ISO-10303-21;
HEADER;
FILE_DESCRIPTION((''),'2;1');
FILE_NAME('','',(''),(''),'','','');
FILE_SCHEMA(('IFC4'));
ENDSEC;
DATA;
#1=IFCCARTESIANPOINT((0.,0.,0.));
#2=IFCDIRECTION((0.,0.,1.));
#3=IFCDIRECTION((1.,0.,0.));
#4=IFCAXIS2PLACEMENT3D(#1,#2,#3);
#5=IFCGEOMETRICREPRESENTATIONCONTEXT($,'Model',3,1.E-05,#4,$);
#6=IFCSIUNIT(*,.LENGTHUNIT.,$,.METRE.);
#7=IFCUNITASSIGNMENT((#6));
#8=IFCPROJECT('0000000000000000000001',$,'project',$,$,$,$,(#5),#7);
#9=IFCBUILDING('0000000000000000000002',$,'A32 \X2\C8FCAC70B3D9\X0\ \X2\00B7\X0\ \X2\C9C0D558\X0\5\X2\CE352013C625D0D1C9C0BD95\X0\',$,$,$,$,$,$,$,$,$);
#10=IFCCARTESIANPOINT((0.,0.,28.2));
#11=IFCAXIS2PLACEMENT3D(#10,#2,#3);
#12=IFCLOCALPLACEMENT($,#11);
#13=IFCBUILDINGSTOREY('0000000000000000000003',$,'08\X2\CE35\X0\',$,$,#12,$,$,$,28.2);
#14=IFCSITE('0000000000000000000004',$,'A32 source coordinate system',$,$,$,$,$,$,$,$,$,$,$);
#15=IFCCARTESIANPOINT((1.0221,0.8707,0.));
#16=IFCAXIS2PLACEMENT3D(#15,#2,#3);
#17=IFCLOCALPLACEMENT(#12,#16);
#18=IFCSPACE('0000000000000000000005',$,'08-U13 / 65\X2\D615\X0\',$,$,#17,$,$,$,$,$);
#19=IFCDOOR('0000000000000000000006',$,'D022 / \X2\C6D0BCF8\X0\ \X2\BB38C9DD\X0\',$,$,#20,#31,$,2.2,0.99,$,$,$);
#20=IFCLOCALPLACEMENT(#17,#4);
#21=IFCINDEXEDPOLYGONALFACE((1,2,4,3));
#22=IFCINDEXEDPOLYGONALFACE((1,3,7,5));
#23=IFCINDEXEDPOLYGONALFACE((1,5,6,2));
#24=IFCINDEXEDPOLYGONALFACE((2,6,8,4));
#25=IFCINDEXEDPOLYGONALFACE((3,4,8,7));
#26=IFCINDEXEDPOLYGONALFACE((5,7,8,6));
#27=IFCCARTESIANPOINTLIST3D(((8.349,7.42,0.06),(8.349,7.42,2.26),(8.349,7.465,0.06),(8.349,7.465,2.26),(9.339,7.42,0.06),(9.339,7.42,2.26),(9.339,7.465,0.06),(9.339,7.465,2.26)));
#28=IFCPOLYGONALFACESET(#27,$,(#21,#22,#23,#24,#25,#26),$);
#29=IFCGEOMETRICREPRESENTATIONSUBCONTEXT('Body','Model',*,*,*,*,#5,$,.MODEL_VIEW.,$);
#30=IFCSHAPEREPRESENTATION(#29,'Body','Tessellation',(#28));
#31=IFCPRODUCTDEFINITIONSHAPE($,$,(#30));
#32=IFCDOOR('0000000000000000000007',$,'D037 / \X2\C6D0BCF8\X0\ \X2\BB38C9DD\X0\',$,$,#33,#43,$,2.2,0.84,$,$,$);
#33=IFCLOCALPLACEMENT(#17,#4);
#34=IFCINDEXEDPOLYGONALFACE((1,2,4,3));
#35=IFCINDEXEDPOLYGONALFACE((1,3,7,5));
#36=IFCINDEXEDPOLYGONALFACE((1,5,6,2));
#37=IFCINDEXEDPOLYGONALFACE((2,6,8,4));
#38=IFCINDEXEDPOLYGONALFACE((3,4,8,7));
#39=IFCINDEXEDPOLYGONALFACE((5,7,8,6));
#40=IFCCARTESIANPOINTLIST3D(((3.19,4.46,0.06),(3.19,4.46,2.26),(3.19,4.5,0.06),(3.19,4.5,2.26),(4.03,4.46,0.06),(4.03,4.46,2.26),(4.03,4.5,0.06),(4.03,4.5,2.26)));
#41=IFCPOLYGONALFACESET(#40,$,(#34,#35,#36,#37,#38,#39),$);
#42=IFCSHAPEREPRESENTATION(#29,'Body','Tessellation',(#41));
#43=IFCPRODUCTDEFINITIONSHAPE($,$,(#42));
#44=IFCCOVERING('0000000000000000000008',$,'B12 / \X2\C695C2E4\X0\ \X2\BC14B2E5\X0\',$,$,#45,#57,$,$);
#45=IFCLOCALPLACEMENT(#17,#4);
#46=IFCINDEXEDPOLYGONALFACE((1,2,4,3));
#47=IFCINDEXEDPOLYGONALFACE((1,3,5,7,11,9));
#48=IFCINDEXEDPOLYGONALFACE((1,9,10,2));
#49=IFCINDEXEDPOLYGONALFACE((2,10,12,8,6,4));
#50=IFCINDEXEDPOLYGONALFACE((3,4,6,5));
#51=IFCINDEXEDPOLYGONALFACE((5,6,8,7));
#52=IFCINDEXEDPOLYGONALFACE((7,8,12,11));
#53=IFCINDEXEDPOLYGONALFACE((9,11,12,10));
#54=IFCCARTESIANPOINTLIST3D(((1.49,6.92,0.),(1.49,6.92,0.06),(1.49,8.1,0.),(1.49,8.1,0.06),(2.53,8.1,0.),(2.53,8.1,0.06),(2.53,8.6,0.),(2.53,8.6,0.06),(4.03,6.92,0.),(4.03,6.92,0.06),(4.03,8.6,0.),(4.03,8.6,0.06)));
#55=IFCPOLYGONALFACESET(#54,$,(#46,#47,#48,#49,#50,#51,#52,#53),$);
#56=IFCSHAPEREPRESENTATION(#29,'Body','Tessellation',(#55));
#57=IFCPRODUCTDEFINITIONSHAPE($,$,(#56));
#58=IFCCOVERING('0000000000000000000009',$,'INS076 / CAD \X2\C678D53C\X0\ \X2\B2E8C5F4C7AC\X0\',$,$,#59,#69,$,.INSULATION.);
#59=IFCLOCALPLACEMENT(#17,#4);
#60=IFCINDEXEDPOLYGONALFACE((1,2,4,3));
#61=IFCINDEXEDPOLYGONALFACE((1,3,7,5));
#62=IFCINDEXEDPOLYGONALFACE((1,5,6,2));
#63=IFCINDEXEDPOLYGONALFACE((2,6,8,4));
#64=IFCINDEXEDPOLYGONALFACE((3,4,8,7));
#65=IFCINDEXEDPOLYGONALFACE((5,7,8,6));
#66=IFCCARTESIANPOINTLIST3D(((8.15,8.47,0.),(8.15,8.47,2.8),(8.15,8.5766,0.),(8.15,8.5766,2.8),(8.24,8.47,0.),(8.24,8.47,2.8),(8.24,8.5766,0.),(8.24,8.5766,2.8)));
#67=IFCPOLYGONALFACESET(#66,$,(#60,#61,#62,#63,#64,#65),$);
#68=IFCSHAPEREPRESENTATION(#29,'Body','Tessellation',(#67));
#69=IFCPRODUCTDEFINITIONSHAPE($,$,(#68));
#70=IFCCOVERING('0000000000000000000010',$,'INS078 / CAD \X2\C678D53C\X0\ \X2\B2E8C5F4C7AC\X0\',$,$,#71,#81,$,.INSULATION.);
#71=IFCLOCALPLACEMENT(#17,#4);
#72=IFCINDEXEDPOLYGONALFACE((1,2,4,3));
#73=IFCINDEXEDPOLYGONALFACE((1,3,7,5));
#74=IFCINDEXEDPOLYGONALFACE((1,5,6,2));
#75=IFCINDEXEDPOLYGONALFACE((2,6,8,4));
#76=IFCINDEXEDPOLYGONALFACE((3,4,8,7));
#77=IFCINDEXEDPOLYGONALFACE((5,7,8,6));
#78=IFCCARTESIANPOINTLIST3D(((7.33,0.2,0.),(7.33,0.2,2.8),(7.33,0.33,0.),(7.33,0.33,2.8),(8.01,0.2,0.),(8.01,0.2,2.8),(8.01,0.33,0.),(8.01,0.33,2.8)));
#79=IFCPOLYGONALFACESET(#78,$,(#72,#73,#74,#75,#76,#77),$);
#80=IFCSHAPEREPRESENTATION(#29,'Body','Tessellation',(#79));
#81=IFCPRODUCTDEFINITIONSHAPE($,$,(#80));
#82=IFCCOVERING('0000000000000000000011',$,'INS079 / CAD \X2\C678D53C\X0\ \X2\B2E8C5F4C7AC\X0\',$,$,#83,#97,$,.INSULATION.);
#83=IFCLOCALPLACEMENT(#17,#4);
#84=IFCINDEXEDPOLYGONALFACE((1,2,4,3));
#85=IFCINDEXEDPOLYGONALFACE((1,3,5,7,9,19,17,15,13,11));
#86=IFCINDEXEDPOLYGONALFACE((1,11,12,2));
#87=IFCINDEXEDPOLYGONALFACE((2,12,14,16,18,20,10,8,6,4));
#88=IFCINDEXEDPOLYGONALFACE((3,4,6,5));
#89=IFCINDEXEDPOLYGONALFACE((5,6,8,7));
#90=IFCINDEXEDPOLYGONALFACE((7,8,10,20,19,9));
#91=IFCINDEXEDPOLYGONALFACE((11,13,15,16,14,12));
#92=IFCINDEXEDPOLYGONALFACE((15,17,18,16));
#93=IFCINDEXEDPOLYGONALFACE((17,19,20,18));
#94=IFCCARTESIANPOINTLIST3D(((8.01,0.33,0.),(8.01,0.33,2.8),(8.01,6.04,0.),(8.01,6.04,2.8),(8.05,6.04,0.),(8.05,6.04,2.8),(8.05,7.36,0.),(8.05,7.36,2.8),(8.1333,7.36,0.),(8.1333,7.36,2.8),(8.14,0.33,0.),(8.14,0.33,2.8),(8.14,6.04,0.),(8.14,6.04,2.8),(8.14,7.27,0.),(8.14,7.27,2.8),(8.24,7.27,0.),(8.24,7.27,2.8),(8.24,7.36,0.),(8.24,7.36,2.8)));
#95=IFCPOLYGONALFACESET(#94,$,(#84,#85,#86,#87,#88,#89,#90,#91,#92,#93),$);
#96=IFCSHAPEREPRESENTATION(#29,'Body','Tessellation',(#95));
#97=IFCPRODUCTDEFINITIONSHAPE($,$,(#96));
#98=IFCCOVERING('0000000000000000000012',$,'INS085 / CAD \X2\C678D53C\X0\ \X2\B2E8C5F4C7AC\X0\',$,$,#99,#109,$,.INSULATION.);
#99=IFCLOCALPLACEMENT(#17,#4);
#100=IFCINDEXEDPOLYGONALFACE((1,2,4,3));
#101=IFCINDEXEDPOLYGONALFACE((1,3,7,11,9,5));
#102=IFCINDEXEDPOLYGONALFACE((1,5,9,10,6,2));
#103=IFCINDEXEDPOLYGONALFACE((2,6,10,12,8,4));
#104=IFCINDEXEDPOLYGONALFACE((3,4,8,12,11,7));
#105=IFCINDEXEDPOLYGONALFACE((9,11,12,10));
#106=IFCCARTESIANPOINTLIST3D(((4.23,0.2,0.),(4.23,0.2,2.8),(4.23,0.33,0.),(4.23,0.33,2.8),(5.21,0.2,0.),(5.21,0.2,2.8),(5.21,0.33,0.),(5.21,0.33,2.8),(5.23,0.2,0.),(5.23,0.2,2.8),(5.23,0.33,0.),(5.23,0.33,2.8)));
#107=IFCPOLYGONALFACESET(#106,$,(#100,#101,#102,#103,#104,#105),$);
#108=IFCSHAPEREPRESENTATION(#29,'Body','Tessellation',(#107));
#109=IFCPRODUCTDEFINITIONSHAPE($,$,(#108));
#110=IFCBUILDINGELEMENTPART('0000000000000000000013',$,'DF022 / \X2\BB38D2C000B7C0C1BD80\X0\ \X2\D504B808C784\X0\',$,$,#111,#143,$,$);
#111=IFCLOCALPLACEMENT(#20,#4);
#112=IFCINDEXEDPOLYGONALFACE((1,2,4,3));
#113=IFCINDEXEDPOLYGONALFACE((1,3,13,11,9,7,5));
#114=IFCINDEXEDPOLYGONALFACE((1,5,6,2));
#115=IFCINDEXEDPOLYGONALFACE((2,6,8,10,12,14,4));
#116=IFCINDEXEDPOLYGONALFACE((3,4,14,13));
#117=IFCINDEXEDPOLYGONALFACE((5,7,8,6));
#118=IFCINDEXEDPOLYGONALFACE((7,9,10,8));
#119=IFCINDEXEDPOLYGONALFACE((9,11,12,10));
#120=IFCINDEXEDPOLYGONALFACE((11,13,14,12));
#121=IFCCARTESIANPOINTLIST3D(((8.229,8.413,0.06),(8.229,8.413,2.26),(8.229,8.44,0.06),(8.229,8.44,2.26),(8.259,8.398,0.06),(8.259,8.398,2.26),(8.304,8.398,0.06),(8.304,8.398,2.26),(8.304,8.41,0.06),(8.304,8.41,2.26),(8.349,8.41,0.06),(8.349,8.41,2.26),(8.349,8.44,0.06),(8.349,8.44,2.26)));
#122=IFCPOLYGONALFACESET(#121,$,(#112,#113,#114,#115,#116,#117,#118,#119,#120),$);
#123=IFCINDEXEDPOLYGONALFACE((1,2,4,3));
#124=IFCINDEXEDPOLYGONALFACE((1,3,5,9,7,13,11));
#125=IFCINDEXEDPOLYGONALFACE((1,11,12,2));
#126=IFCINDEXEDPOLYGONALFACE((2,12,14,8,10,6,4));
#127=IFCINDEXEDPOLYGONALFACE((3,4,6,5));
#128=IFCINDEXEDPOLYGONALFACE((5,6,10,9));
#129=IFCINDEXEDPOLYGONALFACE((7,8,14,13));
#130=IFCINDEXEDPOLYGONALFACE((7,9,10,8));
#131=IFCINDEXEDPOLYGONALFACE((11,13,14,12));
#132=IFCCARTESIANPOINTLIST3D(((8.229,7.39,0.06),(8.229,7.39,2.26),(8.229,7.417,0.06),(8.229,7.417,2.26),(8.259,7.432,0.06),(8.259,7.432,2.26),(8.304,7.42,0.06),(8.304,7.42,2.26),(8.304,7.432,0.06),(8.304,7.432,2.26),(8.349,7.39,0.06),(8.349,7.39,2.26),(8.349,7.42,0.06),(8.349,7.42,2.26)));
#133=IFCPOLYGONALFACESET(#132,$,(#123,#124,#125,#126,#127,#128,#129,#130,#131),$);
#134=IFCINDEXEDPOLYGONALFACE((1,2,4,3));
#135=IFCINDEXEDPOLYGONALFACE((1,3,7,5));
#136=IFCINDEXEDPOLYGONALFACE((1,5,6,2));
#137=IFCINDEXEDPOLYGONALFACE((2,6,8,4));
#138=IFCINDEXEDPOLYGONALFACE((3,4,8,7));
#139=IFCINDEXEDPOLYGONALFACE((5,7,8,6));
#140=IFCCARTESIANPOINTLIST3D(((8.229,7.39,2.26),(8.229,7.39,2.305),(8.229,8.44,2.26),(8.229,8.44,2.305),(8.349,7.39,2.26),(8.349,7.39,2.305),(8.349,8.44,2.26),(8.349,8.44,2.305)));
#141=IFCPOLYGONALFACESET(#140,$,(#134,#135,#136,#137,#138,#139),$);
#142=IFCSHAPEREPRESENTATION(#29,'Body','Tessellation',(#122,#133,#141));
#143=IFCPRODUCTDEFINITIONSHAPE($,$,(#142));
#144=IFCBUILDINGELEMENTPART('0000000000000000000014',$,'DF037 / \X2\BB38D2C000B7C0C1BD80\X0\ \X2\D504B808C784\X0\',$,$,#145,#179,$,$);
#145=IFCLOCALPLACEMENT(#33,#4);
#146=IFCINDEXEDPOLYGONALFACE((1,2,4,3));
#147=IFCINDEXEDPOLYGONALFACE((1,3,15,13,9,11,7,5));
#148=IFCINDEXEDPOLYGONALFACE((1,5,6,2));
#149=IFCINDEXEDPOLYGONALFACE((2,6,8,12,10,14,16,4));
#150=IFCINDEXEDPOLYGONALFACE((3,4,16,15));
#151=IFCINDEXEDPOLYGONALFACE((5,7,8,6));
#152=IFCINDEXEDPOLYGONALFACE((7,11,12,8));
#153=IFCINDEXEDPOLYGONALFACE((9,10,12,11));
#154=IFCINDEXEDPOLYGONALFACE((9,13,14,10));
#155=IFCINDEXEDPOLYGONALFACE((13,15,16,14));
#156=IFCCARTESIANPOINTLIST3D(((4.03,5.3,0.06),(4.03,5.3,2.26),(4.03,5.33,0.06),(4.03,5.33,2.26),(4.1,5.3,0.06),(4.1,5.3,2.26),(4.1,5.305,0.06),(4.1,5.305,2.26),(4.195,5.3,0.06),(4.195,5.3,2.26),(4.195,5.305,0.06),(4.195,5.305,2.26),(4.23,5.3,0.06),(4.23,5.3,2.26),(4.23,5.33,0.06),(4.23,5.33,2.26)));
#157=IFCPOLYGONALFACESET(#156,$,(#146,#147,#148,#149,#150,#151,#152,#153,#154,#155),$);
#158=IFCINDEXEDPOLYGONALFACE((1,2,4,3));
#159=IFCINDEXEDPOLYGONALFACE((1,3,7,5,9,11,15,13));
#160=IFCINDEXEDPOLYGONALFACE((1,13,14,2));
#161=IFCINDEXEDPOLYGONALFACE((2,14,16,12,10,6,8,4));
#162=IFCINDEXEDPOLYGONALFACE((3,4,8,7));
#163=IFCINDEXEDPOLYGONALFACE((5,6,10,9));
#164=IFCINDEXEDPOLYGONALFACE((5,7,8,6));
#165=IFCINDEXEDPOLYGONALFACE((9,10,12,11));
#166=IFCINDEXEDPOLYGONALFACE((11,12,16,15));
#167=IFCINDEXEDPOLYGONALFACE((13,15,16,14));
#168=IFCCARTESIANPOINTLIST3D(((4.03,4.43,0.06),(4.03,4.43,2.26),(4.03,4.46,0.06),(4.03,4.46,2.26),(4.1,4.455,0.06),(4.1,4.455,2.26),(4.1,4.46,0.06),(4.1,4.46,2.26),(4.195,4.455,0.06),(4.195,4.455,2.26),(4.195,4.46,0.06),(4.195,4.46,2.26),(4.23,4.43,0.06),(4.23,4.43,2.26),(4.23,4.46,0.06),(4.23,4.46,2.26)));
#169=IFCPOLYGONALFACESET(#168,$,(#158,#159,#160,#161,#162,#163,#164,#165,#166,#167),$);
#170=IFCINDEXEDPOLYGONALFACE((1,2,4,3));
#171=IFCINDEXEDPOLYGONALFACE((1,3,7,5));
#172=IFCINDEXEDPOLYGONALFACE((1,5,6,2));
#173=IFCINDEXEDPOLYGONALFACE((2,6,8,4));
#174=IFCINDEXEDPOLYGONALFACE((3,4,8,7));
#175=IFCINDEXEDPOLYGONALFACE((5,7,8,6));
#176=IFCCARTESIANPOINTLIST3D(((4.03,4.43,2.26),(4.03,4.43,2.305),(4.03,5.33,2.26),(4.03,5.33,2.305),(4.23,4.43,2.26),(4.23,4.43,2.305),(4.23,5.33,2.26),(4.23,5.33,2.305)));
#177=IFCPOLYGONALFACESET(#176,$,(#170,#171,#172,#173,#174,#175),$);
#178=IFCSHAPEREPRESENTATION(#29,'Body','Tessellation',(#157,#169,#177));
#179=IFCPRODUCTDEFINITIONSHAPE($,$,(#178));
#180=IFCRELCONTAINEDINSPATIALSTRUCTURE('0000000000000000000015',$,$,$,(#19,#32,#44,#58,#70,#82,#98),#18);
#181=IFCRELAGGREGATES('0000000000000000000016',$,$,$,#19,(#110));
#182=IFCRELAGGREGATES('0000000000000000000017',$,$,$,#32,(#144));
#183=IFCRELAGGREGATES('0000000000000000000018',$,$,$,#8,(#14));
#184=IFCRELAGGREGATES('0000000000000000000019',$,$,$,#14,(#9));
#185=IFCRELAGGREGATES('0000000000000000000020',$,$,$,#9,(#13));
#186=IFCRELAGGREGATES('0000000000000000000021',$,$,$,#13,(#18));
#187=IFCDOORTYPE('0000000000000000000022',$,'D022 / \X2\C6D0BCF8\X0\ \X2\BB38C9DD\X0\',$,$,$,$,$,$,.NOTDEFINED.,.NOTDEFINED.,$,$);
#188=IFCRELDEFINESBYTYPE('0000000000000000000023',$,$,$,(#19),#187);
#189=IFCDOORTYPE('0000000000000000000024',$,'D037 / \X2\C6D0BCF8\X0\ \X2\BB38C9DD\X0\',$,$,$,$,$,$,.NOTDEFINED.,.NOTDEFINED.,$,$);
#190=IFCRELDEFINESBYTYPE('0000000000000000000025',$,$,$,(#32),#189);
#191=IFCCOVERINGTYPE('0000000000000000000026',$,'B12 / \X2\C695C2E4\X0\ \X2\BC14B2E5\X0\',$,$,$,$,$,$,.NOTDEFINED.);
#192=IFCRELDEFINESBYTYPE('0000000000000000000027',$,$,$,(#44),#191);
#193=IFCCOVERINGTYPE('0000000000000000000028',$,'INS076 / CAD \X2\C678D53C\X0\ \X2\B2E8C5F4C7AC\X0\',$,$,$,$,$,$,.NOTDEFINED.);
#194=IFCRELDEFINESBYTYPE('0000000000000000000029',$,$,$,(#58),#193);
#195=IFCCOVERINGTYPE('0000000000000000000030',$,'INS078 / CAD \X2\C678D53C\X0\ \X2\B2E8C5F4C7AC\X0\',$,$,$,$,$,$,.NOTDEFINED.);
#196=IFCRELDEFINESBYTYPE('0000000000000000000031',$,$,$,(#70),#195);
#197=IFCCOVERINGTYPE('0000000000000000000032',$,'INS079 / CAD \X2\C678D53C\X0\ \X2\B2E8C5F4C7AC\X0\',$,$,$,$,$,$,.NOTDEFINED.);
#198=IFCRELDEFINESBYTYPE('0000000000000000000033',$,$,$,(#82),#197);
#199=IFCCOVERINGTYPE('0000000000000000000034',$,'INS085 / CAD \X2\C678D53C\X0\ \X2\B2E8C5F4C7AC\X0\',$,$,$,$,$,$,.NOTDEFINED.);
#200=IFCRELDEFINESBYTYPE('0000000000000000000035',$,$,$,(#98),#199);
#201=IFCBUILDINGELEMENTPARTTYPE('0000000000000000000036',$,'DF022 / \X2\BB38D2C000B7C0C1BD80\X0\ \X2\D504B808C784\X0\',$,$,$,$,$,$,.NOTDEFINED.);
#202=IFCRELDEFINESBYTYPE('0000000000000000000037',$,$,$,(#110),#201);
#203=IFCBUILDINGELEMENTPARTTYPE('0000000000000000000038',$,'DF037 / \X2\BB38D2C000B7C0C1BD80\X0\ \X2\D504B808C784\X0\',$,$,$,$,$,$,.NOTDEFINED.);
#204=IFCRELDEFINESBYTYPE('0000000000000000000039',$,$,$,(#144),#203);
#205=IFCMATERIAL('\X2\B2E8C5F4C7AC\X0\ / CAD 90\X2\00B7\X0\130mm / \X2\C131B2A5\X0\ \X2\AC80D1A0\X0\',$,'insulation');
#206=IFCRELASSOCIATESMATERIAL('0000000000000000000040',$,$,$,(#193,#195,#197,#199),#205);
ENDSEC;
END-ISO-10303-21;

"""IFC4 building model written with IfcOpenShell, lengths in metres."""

from ifc_helpers import new_model, si_unit, frame, origin, origin_with_axes, place, context, subcontext, project, spatial, polyline, outline, extrude, source, transform, mapped, material, type_object, type_shapes, element, aggregate, save


model = new_model("IFC4")

# Units and contexts
model_context = context("Model", 3, precision=1e-05, world=origin_with_axes())
body_context = subcontext(model_context, "Body", "Model", "MODEL_VIEW")
ifc_project = project(units=[si_unit("LENGTHUNIT", "METRE")], contexts=[model_context])

# Site, building, storey
site = spatial("IfcSite", under=ifc_project, Name="A32 source coordinate system")
building = spatial("IfcBuilding", under=site, Name="A32 주거동 · 지하5층–옥탑지붕")
storey_placement = place(None, frame((0.0, 0.0, 28.2), z_axis=(0.0, 0.0, 1.0), x_axis=(1.0, 0.0, 0.0)))
storey = spatial("IfcBuildingStorey", under=building, at=storey_placement, Name="08층", Elevation=28.2)

# Shared definitions
space_placement = place(storey_placement, frame((1.0221, 0.8707, 0.0), z_axis=(0.0, 0.0, 1.0), x_axis=(1.0, 0.0, 0.0)))
space = spatial("IfcSpace", under=storey, at=space_placement, Name="08-U13 / 65형")

# Doors
door_type_1 = type_object("IfcDoorType", Name="D022 / 원본 문짝", OperationType="NOTDEFINED", PredefinedType="NOTDEFINED")
shared_shape_1 = source(origin(), body_context, "Body", "SweptSolid", [
    extrude(outline(polyline([(9.339, 7.465), (9.339, 7.42), (8.349, 7.42), (8.349, 7.465), (9.339, 7.465)])), frame((0.0, 0.0, 0.06)), (0.0, 0.0, 1.0), 2.2),
])
type_shapes(door_type_1, [shared_shape_1])
door_1_placement = place(space_placement, origin_with_axes())
door_1 = element("IfcDoor", 1, at=door_1_placement, inside=space, type_object=door_type_1, Name="D022 / 원본 문짝", OverallHeight=2.2, OverallWidth=0.99, context=body_context, shape_type="MappedRepresentation", body=[
    mapped(shared_shape_1, transform((0.0, 0.0, 0.0), scale=1.0)),
])
door_type_2 = type_object("IfcDoorType", Name="D037 / 원본 문짝", OperationType="NOTDEFINED", PredefinedType="NOTDEFINED")
shared_shape_2 = source(origin(), body_context, "Body", "SweptSolid", [
    extrude(outline(polyline([(4.03, 4.46), (3.19, 4.46), (3.19, 4.5), (4.03, 4.5), (4.03, 4.46)])), frame((0.0, 0.0, 0.06)), (0.0, 0.0, 1.0), 2.2),
])
type_shapes(door_type_2, [shared_shape_2])
door_2_placement = place(space_placement, origin_with_axes())
door_2 = element("IfcDoor", 2, at=door_2_placement, inside=space, type_object=door_type_2, Name="D037 / 원본 문짝", OverallHeight=2.2, OverallWidth=0.84, context=body_context, shape_type="MappedRepresentation", body=[
    mapped(shared_shape_2, transform((0.0, 0.0, 0.0), scale=1.0)),
])

# Coverings
covering_type_1 = type_object("IfcCoveringType", Name="B12 / 욕실 바닥", PredefinedType="NOTDEFINED")
shared_shape_3 = source(origin(), body_context, "Body", "SweptSolid", [
    extrude(outline(polyline([(2.53, 8.6), (4.03, 8.6), (4.03, 6.92), (1.49, 6.92), (1.49, 8.1), (2.53, 8.1), (2.53, 8.6)])), origin(), (0.0, 0.0, 1.0), 0.06),
])
type_shapes(covering_type_1, [shared_shape_3])
covering_1_placement = place(space_placement, origin_with_axes())
element("IfcCovering", 3, at=covering_1_placement, inside=space, type_object=covering_type_1, Name="B12 / 욕실 바닥", context=body_context, shape_type="MappedRepresentation", body=[
    mapped(shared_shape_3, transform((0.0, 0.0, 0.0), scale=1.0)),
])
ifc_material = material(Name="단열재 / CAD 90·130mm / 성능 검토", Category="insulation")
covering_type_2 = type_object("IfcCoveringType", Name="INS076 / CAD 외피 단열재", PredefinedType="NOTDEFINED", material=ifc_material)
shared_shape_4 = source(origin(), body_context, "Body", "SweptSolid", [
    extrude(outline(polyline([(8.24, 8.5766), (8.24, 8.47), (8.15, 8.47), (8.15, 8.5766), (8.24, 8.5766)])), origin(), (0.0, 0.0, 1.0), 2.8),
])
type_shapes(covering_type_2, [shared_shape_4])
covering_2_placement = place(space_placement, origin_with_axes())
element("IfcCovering", 4, at=covering_2_placement, inside=space, type_object=covering_type_2, Name="INS076 / CAD 외피 단열재", PredefinedType="INSULATION", context=body_context, shape_type="MappedRepresentation", body=[
    mapped(shared_shape_4, transform((0.0, 0.0, 0.0), scale=1.0)),
])
covering_type_3 = type_object("IfcCoveringType", Name="INS078 / CAD 외피 단열재", PredefinedType="NOTDEFINED", material=ifc_material)
shared_shape_5 = source(origin(), body_context, "Body", "SweptSolid", [
    extrude(outline(polyline([(8.01, 0.2), (7.33, 0.2), (7.33, 0.33), (8.01, 0.33), (8.01, 0.2)])), origin(), (0.0, 0.0, 1.0), 2.8),
])
type_shapes(covering_type_3, [shared_shape_5])
covering_3_placement = place(space_placement, origin_with_axes())
element("IfcCovering", 5, at=covering_3_placement, inside=space, type_object=covering_type_3, Name="INS078 / CAD 외피 단열재", PredefinedType="INSULATION", context=body_context, shape_type="MappedRepresentation", body=[
    mapped(shared_shape_5, transform((0.0, 0.0, 0.0), scale=1.0)),
])
covering_type_4 = type_object("IfcCoveringType", Name="INS079 / CAD 외피 단열재", PredefinedType="NOTDEFINED", material=ifc_material)
shared_shape_6 = source(origin(), body_context, "Body", "SweptSolid", [
    extrude(outline(polyline([(8.24, 7.27), (8.14, 7.27), (8.14, 6.04), (8.14, 0.33), (8.01, 0.33), (8.01, 6.04), (8.05, 6.04), (8.05, 7.36), (8.1333, 7.36), (8.24, 7.36), (8.24, 7.27)])), origin(), (0.0, 0.0, 1.0), 2.8),
])
type_shapes(covering_type_4, [shared_shape_6])
covering_4_placement = place(space_placement, origin_with_axes())
element("IfcCovering", 6, at=covering_4_placement, inside=space, type_object=covering_type_4, Name="INS079 / CAD 외피 단열재", PredefinedType="INSULATION", context=body_context, shape_type="MappedRepresentation", body=[
    mapped(shared_shape_6, transform((0.0, 0.0, 0.0), scale=1.0)),
])
covering_type_5 = type_object("IfcCoveringType", Name="INS085 / CAD 외피 단열재", PredefinedType="NOTDEFINED", material=ifc_material)
shared_shape_7 = source(origin(), body_context, "Body", "SweptSolid", [
    extrude(outline(polyline([(4.23, 0.2), (4.23, 0.33), (5.21, 0.33), (5.23, 0.33), (5.23, 0.2), (5.21, 0.2), (4.23, 0.2)])), origin(), (0.0, 0.0, 1.0), 2.8),
])
type_shapes(covering_type_5, [shared_shape_7])
covering_5_placement = place(space_placement, origin_with_axes())
element("IfcCovering", 7, at=covering_5_placement, inside=space, type_object=covering_type_5, Name="INS085 / CAD 외피 단열재", PredefinedType="INSULATION", context=body_context, shape_type="MappedRepresentation", body=[
    mapped(shared_shape_7, transform((0.0, 0.0, 0.0), scale=1.0)),
])

# Building element parts
building_element_part_type_1 = type_object("IfcBuildingElementPartType", Name="DF022 / 문틀·상부 프레임", PredefinedType="NOTDEFINED")
shared_shape_8 = source(origin(), body_context, "Body", "SweptSolid", [
    extrude(outline(polyline([(8.349, 8.41), (8.304, 8.41), (8.304, 8.398), (8.259, 8.398), (8.229, 8.413), (8.229, 8.44), (8.349, 8.44), (8.349, 8.41)])), frame((0.0, 0.0, 0.06)), (0.0, 0.0, 1.0), 2.2),
    extrude(outline(polyline([(8.229, 7.39), (8.229, 7.417), (8.259, 7.432), (8.304, 7.432), (8.304, 7.42), (8.349, 7.42), (8.349, 7.39), (8.229, 7.39)])), frame((0.0, 0.0, 0.06)), (0.0, 0.0, 1.0), 2.2),
    extrude(outline(polyline([(8.229, 7.39), (8.229, 8.44), (8.349, 8.44), (8.349, 7.39), (8.229, 7.39)])), frame((0.0, 0.0, 2.26)), (0.0, 0.0, 1.0), 0.045),
])
type_shapes(building_element_part_type_1, [shared_shape_8])
building_element_part_1_placement = place(door_1_placement, origin_with_axes())
building_element_part_1 = element("IfcBuildingElementPart", 8, at=building_element_part_1_placement, type_object=building_element_part_type_1, Name="DF022 / 문틀·상부 프레임", context=body_context, shape_type="MappedRepresentation", body=[
    mapped(shared_shape_8, transform((0.0, 0.0, 0.0), scale=1.0)),
])
aggregate(door_1, [building_element_part_1])
building_element_part_type_2 = type_object("IfcBuildingElementPartType", Name="DF037 / 문틀·상부 프레임", PredefinedType="NOTDEFINED")
shared_shape_9 = source(origin(), body_context, "Body", "SweptSolid", [
    extrude(outline(polyline([(4.23, 5.33), (4.23, 5.3), (4.195, 5.3), (4.195, 5.305), (4.1, 5.305), (4.1, 5.3), (4.03, 5.3), (4.03, 5.33), (4.23, 5.33)])), frame((0.0, 0.0, 0.06)), (0.0, 0.0, 1.0), 2.2),
    extrude(outline(polyline([(4.03, 4.46), (4.1, 4.46), (4.1, 4.455), (4.195, 4.455), (4.195, 4.46), (4.23, 4.46), (4.23, 4.43), (4.03, 4.43), (4.03, 4.46)])), frame((0.0, 0.0, 0.06)), (0.0, 0.0, 1.0), 2.2),
    extrude(outline(polyline([(4.03, 4.43), (4.03, 5.33), (4.23, 5.33), (4.23, 4.43), (4.03, 4.43)])), frame((0.0, 0.0, 2.26)), (0.0, 0.0, 1.0), 0.045),
])
type_shapes(building_element_part_type_2, [shared_shape_9])
building_element_part_2_placement = place(door_2_placement, origin_with_axes())
building_element_part_2 = element("IfcBuildingElementPart", 9, at=building_element_part_2_placement, type_object=building_element_part_type_2, Name="DF037 / 문틀·상부 프레임", context=body_context, shape_type="MappedRepresentation", body=[
    mapped(shared_shape_9, transform((0.0, 0.0, 0.0), scale=1.0)),
])
aggregate(door_2, [building_element_part_2])

save(model, "model.ifc")
